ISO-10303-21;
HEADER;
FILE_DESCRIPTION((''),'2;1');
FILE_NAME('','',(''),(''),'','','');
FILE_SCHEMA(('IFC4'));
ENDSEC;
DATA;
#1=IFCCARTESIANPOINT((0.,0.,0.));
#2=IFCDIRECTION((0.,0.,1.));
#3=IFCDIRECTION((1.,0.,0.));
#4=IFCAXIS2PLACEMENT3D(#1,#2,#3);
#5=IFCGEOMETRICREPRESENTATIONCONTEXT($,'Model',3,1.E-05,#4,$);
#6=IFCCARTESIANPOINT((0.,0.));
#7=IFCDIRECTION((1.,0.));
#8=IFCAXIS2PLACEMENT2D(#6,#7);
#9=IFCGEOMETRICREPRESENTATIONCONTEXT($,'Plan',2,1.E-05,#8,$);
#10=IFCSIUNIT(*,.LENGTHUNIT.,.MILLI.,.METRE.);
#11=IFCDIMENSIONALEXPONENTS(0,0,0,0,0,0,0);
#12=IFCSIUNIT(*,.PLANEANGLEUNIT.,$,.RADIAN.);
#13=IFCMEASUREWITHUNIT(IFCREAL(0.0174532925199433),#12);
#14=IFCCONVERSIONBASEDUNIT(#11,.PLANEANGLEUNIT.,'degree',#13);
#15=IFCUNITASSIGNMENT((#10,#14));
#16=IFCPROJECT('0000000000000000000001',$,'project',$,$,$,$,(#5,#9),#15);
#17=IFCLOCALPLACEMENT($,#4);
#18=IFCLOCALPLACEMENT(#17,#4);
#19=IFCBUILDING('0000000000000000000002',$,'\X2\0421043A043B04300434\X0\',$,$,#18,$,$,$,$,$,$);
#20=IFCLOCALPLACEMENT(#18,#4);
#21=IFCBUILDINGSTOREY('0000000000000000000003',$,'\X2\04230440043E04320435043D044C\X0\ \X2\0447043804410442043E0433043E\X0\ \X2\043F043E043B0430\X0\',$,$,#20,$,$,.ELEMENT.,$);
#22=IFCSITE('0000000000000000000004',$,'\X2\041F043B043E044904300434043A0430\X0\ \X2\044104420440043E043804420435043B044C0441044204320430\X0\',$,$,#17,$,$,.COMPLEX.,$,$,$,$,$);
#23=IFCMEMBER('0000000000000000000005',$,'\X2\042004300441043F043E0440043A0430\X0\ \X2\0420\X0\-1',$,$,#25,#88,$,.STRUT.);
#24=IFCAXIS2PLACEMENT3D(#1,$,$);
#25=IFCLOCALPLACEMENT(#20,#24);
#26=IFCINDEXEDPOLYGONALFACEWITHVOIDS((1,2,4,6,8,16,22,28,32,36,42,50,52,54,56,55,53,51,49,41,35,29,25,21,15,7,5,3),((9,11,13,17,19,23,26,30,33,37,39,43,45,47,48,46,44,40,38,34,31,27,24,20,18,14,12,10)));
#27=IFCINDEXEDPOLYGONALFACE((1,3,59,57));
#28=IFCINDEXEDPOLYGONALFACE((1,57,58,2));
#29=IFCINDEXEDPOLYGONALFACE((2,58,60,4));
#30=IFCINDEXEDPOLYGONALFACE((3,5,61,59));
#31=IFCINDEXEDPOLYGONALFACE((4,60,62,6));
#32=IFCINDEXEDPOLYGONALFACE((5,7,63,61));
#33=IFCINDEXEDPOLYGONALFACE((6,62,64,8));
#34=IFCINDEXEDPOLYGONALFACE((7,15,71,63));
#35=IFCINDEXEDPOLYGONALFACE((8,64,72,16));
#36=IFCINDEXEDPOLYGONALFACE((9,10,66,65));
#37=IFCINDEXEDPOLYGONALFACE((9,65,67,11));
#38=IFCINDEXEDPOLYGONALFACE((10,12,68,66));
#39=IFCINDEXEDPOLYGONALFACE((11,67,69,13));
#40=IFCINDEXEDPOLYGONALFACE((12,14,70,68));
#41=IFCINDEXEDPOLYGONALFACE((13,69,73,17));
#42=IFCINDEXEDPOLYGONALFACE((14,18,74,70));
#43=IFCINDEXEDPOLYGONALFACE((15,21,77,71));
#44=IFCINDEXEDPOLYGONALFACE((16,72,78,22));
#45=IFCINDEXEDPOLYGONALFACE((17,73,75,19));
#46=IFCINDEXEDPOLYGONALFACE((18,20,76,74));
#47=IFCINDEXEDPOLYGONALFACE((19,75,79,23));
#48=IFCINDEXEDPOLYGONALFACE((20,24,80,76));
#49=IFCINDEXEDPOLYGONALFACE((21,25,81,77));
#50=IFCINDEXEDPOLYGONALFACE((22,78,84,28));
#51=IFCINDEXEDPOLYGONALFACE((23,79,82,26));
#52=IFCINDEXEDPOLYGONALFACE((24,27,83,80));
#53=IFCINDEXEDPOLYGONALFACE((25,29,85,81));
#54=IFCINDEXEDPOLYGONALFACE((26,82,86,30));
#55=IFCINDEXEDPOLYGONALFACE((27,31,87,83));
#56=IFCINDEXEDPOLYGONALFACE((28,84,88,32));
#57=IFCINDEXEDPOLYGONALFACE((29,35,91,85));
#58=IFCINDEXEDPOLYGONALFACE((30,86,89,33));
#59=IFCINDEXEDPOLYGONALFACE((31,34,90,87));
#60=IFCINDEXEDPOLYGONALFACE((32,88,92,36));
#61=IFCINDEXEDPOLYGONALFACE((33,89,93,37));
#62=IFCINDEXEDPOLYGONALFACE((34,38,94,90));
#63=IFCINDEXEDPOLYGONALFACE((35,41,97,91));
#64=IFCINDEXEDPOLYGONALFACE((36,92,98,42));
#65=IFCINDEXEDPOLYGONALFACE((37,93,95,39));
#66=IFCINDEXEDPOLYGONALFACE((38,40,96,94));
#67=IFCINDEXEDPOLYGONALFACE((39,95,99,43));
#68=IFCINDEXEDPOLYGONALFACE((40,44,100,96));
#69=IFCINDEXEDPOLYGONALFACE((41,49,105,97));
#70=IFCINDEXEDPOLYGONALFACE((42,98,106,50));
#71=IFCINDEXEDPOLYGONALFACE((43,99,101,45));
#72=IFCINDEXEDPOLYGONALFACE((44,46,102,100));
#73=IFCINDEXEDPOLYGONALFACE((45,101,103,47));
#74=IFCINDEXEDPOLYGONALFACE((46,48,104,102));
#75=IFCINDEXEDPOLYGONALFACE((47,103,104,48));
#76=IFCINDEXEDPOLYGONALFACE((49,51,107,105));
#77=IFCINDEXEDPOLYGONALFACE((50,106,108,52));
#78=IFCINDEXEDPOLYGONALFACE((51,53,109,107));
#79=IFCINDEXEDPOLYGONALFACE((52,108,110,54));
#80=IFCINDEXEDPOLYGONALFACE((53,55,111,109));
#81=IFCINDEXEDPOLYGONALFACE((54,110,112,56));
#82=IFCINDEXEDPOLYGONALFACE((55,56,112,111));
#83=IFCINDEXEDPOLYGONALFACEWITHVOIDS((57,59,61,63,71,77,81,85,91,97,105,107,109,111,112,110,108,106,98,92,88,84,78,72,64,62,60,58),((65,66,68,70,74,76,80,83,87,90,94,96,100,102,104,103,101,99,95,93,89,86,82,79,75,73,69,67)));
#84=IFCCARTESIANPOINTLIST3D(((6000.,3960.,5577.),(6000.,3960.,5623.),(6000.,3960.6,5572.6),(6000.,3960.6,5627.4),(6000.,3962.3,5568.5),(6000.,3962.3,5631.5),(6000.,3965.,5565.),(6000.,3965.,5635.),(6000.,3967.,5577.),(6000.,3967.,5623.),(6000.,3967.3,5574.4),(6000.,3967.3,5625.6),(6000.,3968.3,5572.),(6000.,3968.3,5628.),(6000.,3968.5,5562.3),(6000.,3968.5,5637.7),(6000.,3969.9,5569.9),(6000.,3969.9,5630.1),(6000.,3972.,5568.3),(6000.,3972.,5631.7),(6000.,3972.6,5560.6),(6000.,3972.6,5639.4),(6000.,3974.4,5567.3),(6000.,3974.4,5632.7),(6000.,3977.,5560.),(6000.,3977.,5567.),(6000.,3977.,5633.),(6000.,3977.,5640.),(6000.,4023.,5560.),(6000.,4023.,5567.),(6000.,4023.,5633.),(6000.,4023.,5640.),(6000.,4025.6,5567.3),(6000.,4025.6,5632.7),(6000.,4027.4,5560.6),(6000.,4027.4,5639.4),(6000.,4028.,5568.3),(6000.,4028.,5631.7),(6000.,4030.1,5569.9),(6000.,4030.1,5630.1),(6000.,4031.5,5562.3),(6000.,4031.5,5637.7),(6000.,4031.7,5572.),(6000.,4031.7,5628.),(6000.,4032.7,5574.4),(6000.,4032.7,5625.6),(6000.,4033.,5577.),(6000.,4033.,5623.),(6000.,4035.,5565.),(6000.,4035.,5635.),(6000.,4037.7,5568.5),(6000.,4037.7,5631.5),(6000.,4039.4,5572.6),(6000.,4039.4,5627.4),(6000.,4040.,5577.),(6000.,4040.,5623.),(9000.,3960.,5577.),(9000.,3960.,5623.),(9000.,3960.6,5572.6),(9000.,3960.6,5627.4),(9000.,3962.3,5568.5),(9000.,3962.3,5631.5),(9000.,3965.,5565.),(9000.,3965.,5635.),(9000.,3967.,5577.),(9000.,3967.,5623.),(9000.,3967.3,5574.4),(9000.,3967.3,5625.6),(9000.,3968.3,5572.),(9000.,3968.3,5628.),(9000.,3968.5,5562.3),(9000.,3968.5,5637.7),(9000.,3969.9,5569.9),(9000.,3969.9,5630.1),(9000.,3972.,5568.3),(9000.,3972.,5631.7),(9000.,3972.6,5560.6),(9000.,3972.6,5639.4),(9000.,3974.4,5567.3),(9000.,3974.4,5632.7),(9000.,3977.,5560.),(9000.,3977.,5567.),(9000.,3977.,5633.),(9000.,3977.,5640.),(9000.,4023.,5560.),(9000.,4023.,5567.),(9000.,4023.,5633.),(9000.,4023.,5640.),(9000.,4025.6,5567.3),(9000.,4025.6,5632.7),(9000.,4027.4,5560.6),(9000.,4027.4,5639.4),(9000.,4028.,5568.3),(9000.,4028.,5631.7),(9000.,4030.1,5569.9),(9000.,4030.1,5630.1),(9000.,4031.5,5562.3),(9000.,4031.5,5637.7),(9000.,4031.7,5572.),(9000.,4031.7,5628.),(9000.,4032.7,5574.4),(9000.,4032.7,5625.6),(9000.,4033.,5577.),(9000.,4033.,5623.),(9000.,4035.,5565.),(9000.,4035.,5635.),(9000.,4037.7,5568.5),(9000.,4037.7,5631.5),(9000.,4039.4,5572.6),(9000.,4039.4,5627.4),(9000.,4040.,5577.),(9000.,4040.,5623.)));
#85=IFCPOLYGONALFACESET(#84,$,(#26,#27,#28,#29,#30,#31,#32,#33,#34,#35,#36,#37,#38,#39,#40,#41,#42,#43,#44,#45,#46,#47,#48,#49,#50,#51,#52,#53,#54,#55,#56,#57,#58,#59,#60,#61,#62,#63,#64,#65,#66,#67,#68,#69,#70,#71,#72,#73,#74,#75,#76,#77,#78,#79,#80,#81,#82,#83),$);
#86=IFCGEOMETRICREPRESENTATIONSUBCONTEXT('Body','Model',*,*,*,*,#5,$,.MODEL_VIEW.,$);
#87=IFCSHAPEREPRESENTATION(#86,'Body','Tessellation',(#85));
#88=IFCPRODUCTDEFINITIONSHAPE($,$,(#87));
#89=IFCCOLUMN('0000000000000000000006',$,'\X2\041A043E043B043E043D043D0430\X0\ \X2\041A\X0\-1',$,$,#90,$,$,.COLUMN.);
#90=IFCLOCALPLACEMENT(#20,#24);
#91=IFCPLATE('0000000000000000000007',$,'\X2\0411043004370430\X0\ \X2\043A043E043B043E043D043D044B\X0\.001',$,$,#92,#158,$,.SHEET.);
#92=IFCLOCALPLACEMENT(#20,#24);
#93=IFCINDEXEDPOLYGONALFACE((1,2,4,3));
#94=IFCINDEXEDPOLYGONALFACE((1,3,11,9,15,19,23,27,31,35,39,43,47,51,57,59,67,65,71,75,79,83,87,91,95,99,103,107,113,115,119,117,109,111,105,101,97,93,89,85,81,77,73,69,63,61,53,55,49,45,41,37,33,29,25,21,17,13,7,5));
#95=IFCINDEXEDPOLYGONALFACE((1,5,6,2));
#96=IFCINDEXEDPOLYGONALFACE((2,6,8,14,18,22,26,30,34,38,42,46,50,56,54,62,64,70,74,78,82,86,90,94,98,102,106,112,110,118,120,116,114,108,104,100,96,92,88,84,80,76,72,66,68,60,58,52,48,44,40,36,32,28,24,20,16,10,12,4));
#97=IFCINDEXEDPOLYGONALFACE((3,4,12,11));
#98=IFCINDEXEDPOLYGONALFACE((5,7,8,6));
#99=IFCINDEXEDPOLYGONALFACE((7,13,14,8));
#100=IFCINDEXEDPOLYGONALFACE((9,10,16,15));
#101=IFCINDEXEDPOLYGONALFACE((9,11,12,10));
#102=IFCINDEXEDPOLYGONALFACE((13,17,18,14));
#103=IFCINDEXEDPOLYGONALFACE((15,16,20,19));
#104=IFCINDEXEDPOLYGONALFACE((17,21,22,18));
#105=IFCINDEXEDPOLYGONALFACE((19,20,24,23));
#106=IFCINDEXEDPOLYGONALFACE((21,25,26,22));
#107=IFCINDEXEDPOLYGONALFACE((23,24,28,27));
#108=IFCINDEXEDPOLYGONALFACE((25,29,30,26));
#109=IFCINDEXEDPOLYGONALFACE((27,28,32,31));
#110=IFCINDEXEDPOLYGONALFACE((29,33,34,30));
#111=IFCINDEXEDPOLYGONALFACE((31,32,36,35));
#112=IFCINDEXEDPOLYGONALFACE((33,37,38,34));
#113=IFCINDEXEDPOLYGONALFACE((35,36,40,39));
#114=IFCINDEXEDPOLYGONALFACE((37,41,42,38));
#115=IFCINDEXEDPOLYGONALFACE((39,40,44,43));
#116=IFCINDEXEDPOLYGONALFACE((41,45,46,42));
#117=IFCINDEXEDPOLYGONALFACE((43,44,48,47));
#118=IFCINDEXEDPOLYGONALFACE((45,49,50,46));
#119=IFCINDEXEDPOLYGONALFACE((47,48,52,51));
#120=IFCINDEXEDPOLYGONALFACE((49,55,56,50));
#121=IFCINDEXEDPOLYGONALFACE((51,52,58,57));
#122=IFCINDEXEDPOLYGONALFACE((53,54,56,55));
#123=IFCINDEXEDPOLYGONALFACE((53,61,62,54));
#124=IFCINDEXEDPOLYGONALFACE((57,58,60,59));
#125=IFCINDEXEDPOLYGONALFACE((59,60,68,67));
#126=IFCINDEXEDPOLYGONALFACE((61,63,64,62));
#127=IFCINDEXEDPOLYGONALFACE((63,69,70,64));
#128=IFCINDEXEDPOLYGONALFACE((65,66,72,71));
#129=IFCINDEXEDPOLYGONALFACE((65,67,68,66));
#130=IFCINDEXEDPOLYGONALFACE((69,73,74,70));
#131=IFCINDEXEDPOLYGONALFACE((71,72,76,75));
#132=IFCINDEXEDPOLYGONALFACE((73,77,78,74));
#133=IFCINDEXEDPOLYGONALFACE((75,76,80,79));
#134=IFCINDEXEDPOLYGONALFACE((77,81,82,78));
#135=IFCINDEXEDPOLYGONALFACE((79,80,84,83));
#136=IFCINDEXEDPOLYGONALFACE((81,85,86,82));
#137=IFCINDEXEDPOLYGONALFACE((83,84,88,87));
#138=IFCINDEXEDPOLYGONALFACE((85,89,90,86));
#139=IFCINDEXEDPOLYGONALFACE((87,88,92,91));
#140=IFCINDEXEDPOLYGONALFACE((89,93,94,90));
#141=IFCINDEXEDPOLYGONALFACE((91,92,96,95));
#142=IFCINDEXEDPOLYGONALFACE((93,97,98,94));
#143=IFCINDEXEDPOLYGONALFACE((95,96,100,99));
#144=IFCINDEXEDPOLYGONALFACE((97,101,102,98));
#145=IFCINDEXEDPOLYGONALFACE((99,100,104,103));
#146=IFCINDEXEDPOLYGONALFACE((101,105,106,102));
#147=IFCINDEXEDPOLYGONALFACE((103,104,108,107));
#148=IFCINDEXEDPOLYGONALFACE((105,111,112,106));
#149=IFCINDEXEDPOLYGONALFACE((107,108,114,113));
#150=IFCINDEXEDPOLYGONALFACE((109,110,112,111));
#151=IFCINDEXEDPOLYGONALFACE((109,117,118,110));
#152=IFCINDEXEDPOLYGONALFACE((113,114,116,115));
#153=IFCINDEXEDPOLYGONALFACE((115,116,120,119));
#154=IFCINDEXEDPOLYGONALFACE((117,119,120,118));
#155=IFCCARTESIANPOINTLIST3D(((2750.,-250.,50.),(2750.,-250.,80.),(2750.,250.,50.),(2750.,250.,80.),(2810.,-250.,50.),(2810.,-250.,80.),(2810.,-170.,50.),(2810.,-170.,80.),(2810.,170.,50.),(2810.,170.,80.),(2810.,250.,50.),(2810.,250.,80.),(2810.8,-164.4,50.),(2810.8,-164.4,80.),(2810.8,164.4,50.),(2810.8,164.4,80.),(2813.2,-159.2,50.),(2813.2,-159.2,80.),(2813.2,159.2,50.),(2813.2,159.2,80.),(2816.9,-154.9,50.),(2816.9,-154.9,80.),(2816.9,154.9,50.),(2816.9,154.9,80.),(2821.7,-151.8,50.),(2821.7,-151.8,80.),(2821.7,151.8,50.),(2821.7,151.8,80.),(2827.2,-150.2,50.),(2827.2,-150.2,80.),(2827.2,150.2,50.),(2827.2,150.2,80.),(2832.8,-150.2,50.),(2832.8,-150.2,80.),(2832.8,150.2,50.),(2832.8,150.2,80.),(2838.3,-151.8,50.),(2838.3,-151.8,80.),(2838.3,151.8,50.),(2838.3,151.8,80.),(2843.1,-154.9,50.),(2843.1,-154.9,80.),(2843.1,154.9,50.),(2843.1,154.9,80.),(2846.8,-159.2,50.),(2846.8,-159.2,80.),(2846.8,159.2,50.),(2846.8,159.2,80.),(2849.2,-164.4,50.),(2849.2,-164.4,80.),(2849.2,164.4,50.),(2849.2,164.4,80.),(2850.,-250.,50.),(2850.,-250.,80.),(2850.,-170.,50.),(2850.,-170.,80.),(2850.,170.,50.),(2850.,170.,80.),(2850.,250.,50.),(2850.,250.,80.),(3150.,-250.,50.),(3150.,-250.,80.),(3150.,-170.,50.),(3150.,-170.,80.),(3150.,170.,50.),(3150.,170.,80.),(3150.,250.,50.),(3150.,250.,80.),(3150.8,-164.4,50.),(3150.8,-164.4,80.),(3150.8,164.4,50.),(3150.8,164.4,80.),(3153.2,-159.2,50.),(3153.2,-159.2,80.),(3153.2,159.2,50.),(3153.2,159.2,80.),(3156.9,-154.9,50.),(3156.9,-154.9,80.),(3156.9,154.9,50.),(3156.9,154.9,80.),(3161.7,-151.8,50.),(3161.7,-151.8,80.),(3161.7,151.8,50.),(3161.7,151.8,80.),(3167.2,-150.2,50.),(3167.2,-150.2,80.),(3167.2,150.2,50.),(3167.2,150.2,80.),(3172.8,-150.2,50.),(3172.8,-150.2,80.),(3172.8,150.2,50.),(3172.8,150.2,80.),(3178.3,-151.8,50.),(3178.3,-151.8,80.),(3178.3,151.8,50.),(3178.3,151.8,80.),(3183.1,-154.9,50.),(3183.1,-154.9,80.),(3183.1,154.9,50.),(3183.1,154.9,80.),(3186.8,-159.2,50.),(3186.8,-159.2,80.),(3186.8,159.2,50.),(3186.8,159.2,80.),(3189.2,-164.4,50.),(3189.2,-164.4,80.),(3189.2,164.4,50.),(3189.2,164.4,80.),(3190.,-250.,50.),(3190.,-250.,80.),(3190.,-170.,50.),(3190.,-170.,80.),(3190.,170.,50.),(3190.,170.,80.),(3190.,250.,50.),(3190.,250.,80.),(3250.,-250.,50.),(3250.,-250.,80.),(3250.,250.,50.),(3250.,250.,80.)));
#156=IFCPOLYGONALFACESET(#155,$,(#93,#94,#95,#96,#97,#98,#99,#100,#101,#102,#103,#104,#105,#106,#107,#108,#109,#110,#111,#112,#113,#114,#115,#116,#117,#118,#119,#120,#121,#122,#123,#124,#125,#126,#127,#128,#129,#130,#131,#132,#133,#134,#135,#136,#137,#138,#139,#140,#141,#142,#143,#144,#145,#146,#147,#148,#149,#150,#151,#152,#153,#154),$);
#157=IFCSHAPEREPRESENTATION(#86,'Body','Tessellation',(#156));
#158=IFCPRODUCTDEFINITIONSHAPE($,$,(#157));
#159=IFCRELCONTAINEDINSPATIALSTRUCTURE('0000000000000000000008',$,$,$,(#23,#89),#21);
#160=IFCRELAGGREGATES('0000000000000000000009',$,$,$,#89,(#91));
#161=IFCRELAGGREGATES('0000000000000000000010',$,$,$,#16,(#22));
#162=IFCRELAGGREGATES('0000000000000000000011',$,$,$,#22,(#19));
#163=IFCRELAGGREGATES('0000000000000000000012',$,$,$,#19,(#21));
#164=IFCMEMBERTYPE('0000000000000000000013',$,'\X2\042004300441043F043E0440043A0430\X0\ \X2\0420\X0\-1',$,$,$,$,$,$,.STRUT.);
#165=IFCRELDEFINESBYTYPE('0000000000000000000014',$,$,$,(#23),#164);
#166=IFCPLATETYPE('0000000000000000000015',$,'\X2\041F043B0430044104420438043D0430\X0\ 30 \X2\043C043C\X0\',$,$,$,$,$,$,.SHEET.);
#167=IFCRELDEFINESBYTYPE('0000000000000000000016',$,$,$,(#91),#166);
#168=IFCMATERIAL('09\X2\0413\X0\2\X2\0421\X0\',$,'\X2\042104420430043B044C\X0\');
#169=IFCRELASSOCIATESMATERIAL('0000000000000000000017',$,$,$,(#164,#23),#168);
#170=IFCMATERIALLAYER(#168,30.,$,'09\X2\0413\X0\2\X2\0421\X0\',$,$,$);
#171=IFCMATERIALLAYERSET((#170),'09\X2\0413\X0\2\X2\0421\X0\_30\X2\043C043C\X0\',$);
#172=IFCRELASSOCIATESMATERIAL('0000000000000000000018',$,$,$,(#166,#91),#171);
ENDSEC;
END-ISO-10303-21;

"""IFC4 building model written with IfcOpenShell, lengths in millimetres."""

from ifc_helpers import new_model, entity, si_unit, converted_unit, frame, origin_with_axes, origin_2d_with_axis, place, context, subcontext, project, spatial, line, arc, indexed_curve, hollow_rectangle, outline, extrude, material, layer, layer_set, layer_usage, material_profile, profile_set, profile_usage, type_object, element, aggregate, save


model = new_model("IFC4")

# Units and contexts
model_context = context("Model", 3, precision=1e-05, world=origin_with_axes())
plan_context = context("Plan", 2, precision=1e-05, world=origin_2d_with_axis())
body_context = subcontext(model_context, "Body", "Model", "MODEL_VIEW")
ifc_project = project(units=[si_unit("LENGTHUNIT", "METRE", prefix="MILLI"), converted_unit("PLANEANGLEUNIT", "degree", entity("IfcReal", 0.0174532925199433), si_unit("PLANEANGLEUNIT", "RADIAN"), dimensions=[0, 0, 0, 0, 0, 0, 0])], contexts=[model_context, plan_context])

# Site, building, storey
site_placement = place(None, origin_with_axes())
site = spatial("IfcSite", under=ifc_project, at=site_placement, Name="Площадка строительства", CompositionType="COMPLEX")
building_placement = place(site_placement, origin_with_axes())
building = spatial("IfcBuilding", under=site, at=building_placement, Name="Склад")
storey_placement = place(building_placement, origin_with_axes())
storey = spatial("IfcBuildingStorey", under=building, at=storey_placement, Name="Уровень чистого пола", CompositionType="ELEMENT")

# Member
ifc_material_1 = material(Name="09Г2С", Category="Сталь")
ifc_material_profile_1 = material_profile(ifc_material_1, hollow_rectangle(XDim=80.0, YDim=80.0, WallThickness=7.0, InnerFilletRadius=10.0, OuterFilletRadius=17.0))
ifc_profile_set_1 = profile_set([ifc_material_profile_1], Name="PK80x7_09G2S")
member_type_1 = type_object("IfcMemberType", Name="Распорка Р-1", PredefinedType="STRUT", material=ifc_profile_set_1)
ifc_profile_usage_1 = profile_usage(ifc_profile_set_1, cardinal=5)
member_1_placement = place(storey_placement, frame((6000.0, 4000.0, 5600.0), z_axis=(1.0, 0.0, 0.0), x_axis=(0.0, 1.0, 0.0)))
element("IfcMember", 1, at=member_1_placement, inside=storey, type_object=member_type_1, material=ifc_profile_usage_1, Name="Распорка Р-1", PredefinedType="STRUT", context=body_context, shape_type="SweptSolid", body=[
    extrude(hollow_rectangle(XDim=80.0, YDim=80.0, WallThickness=7.0, InnerFilletRadius=10.0, OuterFilletRadius=17.0), origin_with_axes(), (0.0, 0.0, 1.0), 3000.0),
])

# Column, plate
column_1_placement = place(storey_placement, origin_with_axes())
column_1 = element("IfcColumn", 2, at=column_1_placement, inside=storey, Name="Колонна К-1", PredefinedType="COLUMN")
ifc_layer = layer(ifc_material_1, 30.0, Name="09Г2С")
ifc_layer_set = layer_set([ifc_layer], Name="09Г2С_30мм")
ifc_layer_usage_1 = layer_usage(ifc_layer_set, "AXIS3", "POSITIVE", 0.0)
plate_type = type_object("IfcPlateType", Name="Пластина 30 мм", PredefinedType="SHEET", material=ifc_layer_set)
plate_1_placement = place(column_1_placement, frame((3000.0, 0.0, 50.0), z_axis=(0.0, 0.0, 1.0), x_axis=(1.0, 0.0, 0.0)))
plate_1 = element("IfcPlate", 3, at=plate_1_placement, type_object=plate_type, material=ifc_layer_usage_1, Name="База колонны.001", PredefinedType="SHEET", context=body_context, shape_type="SweptSolid", body=[
    extrude(outline(indexed_curve([(190.0, 250.0), (250.0, 250.0), (250.0, -250.0), (190.0, -250.0), (190.0, -170.0), (170.0, -150.0), (150.0, -170.0), (150.0, -250.0), (-150.0, -250.0), (-150.0, -170.0), (-170.0, -150.0), (-190.0, -170.0), (-190.0, -250.0), (-250.0, -250.0), (-250.0, 250.0), (-190.0, 250.0), (-190.0, 170.0), (-170.0, 150.0), (-150.0, 170.0), (-150.0, 250.0), (150.0, 250.0), (150.0, 170.0), (170.0, 150.0), (190.0, 170.0)], segments=[line(21, 20), line(20, 19), arc(19, 18, 17), line(17, 16), line(16, 15), line(15, 14), line(14, 13), line(13, 12), arc(12, 11, 10), line(10, 9), line(9, 8), line(8, 7), arc(7, 6, 5), line(5, 4), line(4, 3), line(3, 2), line(2, 1), line(1, 24), arc(24, 23, 22), line(22, 21)], self_intersect=False)), None, (0.0, 0.0, 1.0), 30.0),
])

aggregate(column_1, [plate_1])

save(model, "model.ifc")
